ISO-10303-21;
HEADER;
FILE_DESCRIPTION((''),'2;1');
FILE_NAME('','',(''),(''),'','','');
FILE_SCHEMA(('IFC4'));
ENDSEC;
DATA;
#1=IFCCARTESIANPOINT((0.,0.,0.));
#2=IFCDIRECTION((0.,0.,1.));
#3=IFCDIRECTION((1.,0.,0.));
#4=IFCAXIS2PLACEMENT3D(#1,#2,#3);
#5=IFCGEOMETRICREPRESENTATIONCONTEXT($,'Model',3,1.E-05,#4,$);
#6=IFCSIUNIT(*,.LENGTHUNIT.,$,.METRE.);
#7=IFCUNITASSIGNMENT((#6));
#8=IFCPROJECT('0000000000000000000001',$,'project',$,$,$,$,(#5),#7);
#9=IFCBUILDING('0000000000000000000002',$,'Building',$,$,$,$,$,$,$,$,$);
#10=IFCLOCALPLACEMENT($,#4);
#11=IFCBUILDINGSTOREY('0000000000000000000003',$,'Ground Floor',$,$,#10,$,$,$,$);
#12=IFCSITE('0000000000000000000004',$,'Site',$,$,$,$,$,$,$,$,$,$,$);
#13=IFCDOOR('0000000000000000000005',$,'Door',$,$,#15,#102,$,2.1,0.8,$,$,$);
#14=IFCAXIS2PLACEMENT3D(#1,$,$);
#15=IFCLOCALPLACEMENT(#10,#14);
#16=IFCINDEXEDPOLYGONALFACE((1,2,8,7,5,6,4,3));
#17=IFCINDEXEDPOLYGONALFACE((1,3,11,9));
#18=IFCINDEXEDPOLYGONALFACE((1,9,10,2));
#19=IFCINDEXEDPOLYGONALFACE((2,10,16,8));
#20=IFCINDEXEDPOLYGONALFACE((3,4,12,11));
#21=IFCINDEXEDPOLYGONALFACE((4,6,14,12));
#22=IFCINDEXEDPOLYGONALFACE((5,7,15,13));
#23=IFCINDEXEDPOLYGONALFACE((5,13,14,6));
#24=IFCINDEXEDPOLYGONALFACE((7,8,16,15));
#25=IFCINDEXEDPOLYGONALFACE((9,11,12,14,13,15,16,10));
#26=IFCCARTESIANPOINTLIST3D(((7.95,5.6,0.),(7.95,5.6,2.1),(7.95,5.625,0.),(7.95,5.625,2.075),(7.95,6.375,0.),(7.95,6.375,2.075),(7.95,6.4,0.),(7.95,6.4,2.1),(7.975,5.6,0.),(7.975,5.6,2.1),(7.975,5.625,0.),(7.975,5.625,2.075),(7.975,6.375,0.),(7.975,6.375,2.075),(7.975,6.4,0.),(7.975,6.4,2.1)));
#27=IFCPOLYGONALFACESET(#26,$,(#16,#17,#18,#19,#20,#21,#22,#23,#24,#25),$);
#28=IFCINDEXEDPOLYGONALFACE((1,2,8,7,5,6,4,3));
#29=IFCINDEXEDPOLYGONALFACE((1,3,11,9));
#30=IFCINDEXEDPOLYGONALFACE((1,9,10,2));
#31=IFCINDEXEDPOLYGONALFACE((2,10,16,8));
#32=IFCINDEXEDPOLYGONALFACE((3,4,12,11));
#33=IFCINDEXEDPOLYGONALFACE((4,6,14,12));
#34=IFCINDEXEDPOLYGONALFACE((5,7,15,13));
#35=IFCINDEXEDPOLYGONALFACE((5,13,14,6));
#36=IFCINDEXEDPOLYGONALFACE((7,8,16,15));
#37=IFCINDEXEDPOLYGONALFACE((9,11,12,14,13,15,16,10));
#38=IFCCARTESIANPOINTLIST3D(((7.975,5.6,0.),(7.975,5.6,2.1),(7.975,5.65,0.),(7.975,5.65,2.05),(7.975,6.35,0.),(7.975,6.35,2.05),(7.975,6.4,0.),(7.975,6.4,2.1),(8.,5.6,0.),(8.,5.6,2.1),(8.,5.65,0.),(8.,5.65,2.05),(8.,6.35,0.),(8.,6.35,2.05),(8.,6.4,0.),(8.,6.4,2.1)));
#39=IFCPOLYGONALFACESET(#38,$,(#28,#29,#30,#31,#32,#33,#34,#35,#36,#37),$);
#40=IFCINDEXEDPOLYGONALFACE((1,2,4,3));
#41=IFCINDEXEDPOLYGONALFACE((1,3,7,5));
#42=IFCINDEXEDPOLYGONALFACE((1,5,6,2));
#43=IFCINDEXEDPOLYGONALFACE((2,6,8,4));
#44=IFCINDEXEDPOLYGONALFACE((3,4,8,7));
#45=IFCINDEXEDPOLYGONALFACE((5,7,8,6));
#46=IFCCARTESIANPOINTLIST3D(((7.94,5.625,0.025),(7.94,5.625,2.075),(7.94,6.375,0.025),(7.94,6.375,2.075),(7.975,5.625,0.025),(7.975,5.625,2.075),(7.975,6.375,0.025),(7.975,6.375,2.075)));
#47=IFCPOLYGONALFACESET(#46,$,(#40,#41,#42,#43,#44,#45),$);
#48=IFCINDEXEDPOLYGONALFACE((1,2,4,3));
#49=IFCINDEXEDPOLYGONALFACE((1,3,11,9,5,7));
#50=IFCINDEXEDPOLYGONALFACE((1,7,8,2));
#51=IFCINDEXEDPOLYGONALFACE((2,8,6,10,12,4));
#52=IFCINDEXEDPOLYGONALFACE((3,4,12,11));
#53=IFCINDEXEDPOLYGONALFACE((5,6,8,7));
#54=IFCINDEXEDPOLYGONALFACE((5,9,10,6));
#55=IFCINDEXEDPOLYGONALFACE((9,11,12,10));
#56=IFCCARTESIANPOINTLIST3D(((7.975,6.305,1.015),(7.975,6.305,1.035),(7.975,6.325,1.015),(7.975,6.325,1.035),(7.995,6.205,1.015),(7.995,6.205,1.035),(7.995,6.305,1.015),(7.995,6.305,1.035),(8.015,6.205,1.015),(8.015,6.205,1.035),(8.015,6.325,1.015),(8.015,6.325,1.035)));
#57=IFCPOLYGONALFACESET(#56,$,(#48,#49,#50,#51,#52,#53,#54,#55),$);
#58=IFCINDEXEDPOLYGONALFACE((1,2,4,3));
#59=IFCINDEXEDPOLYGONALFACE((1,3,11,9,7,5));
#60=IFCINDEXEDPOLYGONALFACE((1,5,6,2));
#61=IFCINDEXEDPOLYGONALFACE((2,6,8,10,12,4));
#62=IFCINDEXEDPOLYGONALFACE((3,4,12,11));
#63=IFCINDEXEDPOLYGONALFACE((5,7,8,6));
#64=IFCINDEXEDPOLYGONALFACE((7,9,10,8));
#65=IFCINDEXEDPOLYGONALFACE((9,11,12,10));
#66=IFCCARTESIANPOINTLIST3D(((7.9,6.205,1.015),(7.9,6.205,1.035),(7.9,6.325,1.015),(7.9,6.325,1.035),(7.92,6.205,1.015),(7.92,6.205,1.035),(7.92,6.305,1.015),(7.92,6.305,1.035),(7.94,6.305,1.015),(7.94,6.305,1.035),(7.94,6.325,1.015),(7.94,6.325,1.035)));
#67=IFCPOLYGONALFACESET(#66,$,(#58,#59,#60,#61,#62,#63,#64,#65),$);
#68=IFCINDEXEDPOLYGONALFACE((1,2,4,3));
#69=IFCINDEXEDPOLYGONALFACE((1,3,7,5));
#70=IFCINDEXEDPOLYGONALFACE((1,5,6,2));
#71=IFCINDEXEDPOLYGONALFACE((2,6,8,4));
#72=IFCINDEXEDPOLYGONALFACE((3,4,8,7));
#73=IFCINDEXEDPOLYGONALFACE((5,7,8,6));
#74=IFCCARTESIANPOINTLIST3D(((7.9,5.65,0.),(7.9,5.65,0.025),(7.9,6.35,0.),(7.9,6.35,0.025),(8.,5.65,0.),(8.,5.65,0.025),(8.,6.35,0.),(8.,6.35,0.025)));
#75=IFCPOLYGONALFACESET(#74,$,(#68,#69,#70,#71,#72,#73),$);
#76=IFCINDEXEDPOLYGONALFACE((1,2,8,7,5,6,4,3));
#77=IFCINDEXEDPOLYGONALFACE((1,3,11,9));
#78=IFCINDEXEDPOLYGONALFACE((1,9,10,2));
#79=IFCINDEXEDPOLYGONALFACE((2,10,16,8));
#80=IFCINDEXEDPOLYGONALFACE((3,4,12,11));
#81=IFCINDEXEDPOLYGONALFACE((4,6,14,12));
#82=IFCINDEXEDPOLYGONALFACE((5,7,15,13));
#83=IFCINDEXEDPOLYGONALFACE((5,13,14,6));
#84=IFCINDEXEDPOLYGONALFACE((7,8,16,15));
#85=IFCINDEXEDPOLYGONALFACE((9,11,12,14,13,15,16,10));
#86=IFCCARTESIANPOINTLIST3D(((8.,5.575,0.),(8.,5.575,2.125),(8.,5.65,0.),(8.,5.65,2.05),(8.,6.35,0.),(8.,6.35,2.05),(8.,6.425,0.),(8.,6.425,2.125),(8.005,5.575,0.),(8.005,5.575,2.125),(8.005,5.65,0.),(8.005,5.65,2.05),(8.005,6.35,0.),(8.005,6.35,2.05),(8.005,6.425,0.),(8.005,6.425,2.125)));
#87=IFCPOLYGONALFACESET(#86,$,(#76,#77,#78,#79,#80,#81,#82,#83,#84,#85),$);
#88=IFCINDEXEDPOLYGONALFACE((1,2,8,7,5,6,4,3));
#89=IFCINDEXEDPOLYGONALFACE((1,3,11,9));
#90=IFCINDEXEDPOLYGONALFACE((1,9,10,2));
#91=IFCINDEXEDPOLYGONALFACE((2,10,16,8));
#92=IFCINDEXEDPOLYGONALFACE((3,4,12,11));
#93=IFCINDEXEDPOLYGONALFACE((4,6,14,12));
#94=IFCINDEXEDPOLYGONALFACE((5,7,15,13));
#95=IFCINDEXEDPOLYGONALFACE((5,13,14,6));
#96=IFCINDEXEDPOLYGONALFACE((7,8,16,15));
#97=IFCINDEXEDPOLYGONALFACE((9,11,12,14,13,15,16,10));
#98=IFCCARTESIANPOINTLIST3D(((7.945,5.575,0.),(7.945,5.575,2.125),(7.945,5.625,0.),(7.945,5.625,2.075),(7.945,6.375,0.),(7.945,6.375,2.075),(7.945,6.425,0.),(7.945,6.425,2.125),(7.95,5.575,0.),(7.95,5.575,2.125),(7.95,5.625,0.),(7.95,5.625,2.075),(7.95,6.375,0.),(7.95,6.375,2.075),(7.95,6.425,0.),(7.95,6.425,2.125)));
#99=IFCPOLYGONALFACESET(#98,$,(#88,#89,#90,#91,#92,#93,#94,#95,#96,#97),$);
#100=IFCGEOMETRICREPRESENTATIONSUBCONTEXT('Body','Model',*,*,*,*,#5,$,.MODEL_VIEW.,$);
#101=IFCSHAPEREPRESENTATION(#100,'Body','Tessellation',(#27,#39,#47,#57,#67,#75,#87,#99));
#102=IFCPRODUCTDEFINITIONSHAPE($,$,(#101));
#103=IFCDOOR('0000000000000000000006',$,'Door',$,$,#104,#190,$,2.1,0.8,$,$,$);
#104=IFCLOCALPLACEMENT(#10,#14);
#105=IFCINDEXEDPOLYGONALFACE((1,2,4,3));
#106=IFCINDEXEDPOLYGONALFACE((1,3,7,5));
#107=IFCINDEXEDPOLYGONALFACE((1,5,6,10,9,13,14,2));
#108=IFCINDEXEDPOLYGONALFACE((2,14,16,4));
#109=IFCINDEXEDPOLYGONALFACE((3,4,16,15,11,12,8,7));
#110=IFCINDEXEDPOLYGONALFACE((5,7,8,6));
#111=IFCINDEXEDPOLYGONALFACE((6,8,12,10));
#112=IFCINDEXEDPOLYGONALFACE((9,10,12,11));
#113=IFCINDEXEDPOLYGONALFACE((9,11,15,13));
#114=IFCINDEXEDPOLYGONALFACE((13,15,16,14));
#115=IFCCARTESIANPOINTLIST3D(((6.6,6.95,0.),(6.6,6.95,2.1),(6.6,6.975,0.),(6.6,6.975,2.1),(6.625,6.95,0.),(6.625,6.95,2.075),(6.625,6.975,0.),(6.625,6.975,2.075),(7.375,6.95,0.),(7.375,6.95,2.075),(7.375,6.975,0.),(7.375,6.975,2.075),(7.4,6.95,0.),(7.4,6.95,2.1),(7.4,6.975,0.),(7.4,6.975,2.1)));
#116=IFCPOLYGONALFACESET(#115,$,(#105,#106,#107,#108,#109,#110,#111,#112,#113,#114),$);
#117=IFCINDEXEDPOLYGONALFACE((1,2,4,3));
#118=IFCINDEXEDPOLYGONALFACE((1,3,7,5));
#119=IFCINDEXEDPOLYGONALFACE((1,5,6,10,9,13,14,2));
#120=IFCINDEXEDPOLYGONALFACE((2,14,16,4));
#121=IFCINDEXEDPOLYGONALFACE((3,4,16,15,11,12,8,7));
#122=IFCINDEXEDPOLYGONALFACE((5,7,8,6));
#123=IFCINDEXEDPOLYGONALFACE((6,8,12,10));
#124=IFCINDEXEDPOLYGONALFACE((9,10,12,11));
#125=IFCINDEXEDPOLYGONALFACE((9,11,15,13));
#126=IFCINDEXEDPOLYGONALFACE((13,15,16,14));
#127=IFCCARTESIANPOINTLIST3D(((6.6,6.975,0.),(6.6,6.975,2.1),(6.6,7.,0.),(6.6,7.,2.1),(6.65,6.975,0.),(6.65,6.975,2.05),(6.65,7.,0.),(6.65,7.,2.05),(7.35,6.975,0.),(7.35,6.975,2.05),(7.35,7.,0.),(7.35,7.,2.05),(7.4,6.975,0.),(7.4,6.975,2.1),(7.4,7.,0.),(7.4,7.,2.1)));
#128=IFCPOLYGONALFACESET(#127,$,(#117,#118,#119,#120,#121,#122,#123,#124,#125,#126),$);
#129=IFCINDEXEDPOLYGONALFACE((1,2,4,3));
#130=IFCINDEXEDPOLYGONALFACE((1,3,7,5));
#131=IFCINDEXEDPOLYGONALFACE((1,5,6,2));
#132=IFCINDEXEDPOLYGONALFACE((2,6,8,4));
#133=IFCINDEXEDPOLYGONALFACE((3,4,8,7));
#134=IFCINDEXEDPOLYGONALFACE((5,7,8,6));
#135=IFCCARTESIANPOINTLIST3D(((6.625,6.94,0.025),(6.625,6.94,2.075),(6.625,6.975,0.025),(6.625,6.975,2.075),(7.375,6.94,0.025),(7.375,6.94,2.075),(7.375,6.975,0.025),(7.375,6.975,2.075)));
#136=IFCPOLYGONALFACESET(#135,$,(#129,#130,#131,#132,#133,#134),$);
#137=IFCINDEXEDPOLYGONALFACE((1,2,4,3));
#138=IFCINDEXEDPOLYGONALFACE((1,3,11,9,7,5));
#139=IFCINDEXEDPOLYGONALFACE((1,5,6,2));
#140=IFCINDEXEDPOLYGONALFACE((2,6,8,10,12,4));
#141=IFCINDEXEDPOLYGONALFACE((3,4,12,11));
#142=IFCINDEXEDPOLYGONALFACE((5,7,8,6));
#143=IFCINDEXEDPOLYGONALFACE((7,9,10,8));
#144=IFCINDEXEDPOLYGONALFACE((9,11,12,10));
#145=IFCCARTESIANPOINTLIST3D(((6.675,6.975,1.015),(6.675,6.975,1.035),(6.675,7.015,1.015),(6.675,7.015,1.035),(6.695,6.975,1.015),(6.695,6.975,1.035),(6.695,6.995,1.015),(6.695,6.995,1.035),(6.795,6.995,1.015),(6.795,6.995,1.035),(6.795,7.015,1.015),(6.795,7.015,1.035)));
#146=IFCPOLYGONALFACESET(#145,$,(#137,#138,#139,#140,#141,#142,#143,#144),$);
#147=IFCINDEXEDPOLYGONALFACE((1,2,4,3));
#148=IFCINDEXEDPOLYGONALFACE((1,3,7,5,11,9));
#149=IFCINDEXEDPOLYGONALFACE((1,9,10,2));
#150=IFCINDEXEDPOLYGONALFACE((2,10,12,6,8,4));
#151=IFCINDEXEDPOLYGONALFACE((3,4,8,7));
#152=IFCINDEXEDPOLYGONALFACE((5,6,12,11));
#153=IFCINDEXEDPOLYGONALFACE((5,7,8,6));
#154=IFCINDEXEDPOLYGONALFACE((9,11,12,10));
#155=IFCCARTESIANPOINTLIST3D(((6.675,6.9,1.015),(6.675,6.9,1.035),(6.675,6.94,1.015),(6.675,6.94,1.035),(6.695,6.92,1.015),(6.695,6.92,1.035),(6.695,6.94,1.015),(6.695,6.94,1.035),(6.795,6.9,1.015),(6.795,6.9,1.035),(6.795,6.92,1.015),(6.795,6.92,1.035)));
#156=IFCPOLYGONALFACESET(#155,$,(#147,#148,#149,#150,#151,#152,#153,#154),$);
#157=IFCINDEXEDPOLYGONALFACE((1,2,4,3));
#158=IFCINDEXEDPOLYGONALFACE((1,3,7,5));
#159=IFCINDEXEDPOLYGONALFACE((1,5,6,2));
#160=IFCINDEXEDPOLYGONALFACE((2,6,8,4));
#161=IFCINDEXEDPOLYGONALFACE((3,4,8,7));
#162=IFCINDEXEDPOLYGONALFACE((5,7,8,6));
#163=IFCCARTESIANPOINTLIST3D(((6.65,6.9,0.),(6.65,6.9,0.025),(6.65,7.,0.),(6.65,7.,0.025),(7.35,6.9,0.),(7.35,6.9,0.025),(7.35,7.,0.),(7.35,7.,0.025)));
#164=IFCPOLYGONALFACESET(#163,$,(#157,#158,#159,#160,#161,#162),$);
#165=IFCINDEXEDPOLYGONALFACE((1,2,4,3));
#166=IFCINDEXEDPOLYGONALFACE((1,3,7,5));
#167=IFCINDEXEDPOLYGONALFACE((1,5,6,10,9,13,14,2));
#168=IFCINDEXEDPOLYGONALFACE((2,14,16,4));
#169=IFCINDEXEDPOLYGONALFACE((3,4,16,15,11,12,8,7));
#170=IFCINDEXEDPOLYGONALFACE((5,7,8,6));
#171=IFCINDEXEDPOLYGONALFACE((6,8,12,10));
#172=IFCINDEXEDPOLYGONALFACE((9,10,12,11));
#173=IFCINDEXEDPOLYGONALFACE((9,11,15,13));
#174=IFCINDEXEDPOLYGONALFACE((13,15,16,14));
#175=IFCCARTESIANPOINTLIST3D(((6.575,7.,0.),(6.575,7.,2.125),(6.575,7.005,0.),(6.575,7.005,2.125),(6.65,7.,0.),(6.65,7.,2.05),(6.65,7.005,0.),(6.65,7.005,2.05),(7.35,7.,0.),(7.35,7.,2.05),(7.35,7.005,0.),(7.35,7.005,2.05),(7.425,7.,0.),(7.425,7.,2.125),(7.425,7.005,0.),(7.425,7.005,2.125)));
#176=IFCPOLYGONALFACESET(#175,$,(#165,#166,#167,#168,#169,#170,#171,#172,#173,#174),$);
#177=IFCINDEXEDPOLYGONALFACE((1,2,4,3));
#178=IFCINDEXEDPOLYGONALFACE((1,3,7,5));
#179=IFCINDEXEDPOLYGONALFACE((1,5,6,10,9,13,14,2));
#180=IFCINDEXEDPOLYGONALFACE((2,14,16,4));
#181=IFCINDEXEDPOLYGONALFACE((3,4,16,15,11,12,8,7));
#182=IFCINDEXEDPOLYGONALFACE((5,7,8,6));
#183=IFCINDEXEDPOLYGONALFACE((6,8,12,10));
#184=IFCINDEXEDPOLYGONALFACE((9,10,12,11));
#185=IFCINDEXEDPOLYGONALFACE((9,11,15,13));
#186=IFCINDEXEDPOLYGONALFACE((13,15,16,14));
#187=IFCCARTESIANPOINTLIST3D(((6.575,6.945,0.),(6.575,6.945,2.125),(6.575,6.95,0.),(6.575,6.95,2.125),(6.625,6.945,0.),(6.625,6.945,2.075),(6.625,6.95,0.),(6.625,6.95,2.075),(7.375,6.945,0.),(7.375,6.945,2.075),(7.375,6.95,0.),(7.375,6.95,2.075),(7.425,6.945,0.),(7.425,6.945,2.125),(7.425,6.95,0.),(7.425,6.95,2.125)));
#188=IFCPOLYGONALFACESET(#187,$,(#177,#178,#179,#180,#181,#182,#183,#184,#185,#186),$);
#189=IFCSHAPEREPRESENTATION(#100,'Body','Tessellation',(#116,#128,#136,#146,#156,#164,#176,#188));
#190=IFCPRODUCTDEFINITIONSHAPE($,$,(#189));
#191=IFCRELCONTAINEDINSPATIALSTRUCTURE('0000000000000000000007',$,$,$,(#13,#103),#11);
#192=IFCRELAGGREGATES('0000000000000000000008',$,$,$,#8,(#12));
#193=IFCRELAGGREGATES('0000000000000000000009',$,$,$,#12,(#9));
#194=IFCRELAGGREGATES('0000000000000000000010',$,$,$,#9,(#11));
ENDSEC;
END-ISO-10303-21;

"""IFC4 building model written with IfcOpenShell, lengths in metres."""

from ifc_helpers import new_model, si_unit, frame, origin_with_axes, place, context, subcontext, project, spatial, line, indexed_curve, outline, extrude, element, save


model = new_model("IFC4")

# Units and contexts
model_context = context("Model", 3, precision=1e-05, world=origin_with_axes())
body_context = subcontext(model_context, "Body", "Model", "MODEL_VIEW")
ifc_project = project(units=[si_unit("LENGTHUNIT", "METRE")], contexts=[model_context])

# Site, building, storey
site = spatial("IfcSite", under=ifc_project, Name="Site")
building = spatial("IfcBuilding", under=site, Name="Building")
storey_placement = place(None, origin_with_axes())
storey = spatial("IfcBuildingStorey", under=building, at=storey_placement, Name="Ground Floor")

# Doors
door_1_placement = place(storey_placement, frame((8.0, 5.6, 0.0), z_axis=(0.0, 0.0, 1.0), x_axis=(0.0, 1.0, 0.0)))
element("IfcDoor", 1, at=door_1_placement, inside=storey, Name="Door", OverallHeight=2.1, OverallWidth=0.8, context=body_context, shape_type="SweptSolid", body=[
    extrude(outline(indexed_curve([(0.0, 0.0), (0.0, 2.1), (0.8, 2.1), (0.8, 0.0), (0.775, 0.0), (0.775, 2.075), (0.025, 2.075), (0.025, 0.0)], segments=[line(1, 2, 3, 4, 5, 6, 7, 8, 1)])), frame((0.0, 0.025, 0.0), z_axis=(0.0, -1.0, 0.0), x_axis=(1.0, 0.0, 0.0)), (0.0, 0.0, -1.0), 0.025),
    extrude(outline(indexed_curve([(0.0, 0.0), (0.0, 2.1), (0.8, 2.1), (0.8, 0.0), (0.75, 0.0), (0.75, 2.05), (0.05, 2.05), (0.05, 0.0)], segments=[line(1, 2, 3, 4, 5, 6, 7, 8, 1)])), frame((0.0, 0.0, 0.0), z_axis=(0.0, -1.0, 0.0), x_axis=(1.0, 0.0, 0.0)), (0.0, 0.0, -1.0), 0.025),
    extrude(outline(indexed_curve([(0.0, 0.0), (0.75, 0.0), (0.75, 0.035), (0.0, 0.035)], segments=[line(1, 2, 3, 4, 1)])), frame((0.025, 0.025, 0.025), z_axis=(0.0, 0.0, 1.0), x_axis=(1.0, 0.0, 0.0)), (0.0, 0.0, 1.0), 2.05),
    extrude(outline(indexed_curve([(0.0, 0.0), (0.0, -0.04), (-0.12, -0.04), (-0.12, -0.02), (-0.02, -0.02), (-0.02, 0.0)], segments=[line(1, 2, 3, 4, 5, 6, 1)])), frame((0.725, 0.025, 1.015), z_axis=(0.0, 0.0, 1.0), x_axis=(1.0, 0.0, 0.0)), (0.0, 0.0, 1.0), 0.02),
    extrude(outline(indexed_curve([(0.0, 0.0), (0.0, 0.04), (-0.12, 0.04), (-0.12, 0.02), (-0.02, 0.02), (-0.02, 0.0)], segments=[line(1, 2, 3, 4, 5, 6, 1)])), frame((0.725, 0.06, 1.015), z_axis=(0.0, 0.0, 1.0), x_axis=(1.0, 0.0, 0.0)), (0.0, 0.0, 1.0), 0.02),
    extrude(outline(indexed_curve([(0.0, 0.0), (0.7, 0.0), (0.7, 0.1), (0.0, 0.1)], segments=[line(1, 2, 3, 4, 1)])), frame((0.05, 0.0, 0.0), z_axis=(0.0, 0.0, 1.0), x_axis=(1.0, 0.0, 0.0)), (0.0, 0.0, 1.0), 0.025),
    extrude(outline(indexed_curve([(0.0, 0.0), (0.0, 2.125), (0.85, 2.125), (0.85, 0.0), (0.775, 0.0), (0.775, 2.05), (0.075, 2.05), (0.075, 0.0)], segments=[line(1, 2, 3, 4, 5, 6, 7, 8, 1)])), frame((-0.025, -0.005, 0.0), z_axis=(0.0, -1.0, 0.0), x_axis=(1.0, 0.0, 0.0)), (0.0, 0.0, -1.0), 0.005),
    extrude(outline(indexed_curve([(0.0, 0.0), (0.0, 2.125), (0.85, 2.125), (0.85, 0.0), (0.8, 0.0), (0.8, 2.075), (0.05, 2.075), (0.05, 0.0)], segments=[line(1, 2, 3, 4, 5, 6, 7, 8, 1)])), frame((-0.025, 0.05, 0.0), z_axis=(0.0, -1.0, 0.0), x_axis=(1.0, 0.0, 0.0)), (0.0, 0.0, -1.0), 0.005),
])
door_2_placement = place(storey_placement, frame((7.4, 7.0, 0.0), z_axis=(0.0, 0.0, 1.0), x_axis=(-1.0, 0.0, 0.0)))
element("IfcDoor", 2, at=door_2_placement, inside=storey, Name="Door", OverallHeight=2.1, OverallWidth=0.8, context=body_context, shape_type="SweptSolid", body=[
    extrude(outline(indexed_curve([(0.0, 0.0), (0.0, 2.1), (0.8, 2.1), (0.8, 0.0), (0.775, 0.0), (0.775, 2.075), (0.025, 2.075), (0.025, 0.0)], segments=[line(1, 2, 3, 4, 5, 6, 7, 8, 1)])), frame((0.0, 0.025, 0.0), z_axis=(0.0, -1.0, 0.0), x_axis=(1.0, 0.0, 0.0)), (0.0, 0.0, -1.0), 0.025),
    extrude(outline(indexed_curve([(0.0, 0.0), (0.0, 2.1), (0.8, 2.1), (0.8, 0.0), (0.75, 0.0), (0.75, 2.05), (0.05, 2.05), (0.05, 0.0)], segments=[line(1, 2, 3, 4, 5, 6, 7, 8, 1)])), frame((0.0, 0.0, 0.0), z_axis=(0.0, -1.0, 0.0), x_axis=(1.0, 0.0, 0.0)), (0.0, 0.0, -1.0), 0.025),
    extrude(outline(indexed_curve([(0.0, 0.0), (0.75, 0.0), (0.75, 0.035), (0.0, 0.035)], segments=[line(1, 2, 3, 4, 1)])), frame((0.025, 0.025, 0.025), z_axis=(0.0, 0.0, 1.0), x_axis=(1.0, 0.0, 0.0)), (0.0, 0.0, 1.0), 2.05),
    extrude(outline(indexed_curve([(0.0, 0.0), (0.0, -0.04), (-0.12, -0.04), (-0.12, -0.02), (-0.02, -0.02), (-0.02, 0.0)], segments=[line(1, 2, 3, 4, 5, 6, 1)])), frame((0.725, 0.025, 1.015), z_axis=(0.0, 0.0, 1.0), x_axis=(1.0, 0.0, 0.0)), (0.0, 0.0, 1.0), 0.02),
    extrude(outline(indexed_curve([(0.0, 0.0), (0.0, 0.04), (-0.12, 0.04), (-0.12, 0.02), (-0.02, 0.02), (-0.02, 0.0)], segments=[line(1, 2, 3, 4, 5, 6, 1)])), frame((0.725, 0.06, 1.015), z_axis=(0.0, 0.0, 1.0), x_axis=(1.0, 0.0, 0.0)), (0.0, 0.0, 1.0), 0.02),
    extrude(outline(indexed_curve([(0.0, 0.0), (0.7, 0.0), (0.7, 0.1), (0.0, 0.1)], segments=[line(1, 2, 3, 4, 1)])), frame((0.05, 0.0, 0.0), z_axis=(0.0, 0.0, 1.0), x_axis=(1.0, 0.0, 0.0)), (0.0, 0.0, 1.0), 0.025),
    extrude(outline(indexed_curve([(0.0, 0.0), (0.0, 2.125), (0.85, 2.125), (0.85, 0.0), (0.775, 0.0), (0.775, 2.05), (0.075, 2.05), (0.075, 0.0)], segments=[line(1, 2, 3, 4, 5, 6, 7, 8, 1)])), frame((-0.025, -0.005, 0.0), z_axis=(0.0, -1.0, 0.0), x_axis=(1.0, 0.0, 0.0)), (0.0, 0.0, -1.0), 0.005),
    extrude(outline(indexed_curve([(0.0, 0.0), (0.0, 2.125), (0.85, 2.125), (0.85, 0.0), (0.8, 0.0), (0.8, 2.075), (0.05, 2.075), (0.05, 0.0)], segments=[line(1, 2, 3, 4, 5, 6, 7, 8, 1)])), frame((-0.025, 0.05, 0.0), z_axis=(0.0, -1.0, 0.0), x_axis=(1.0, 0.0, 0.0)), (0.0, 0.0, -1.0), 0.005),
])

save(model, "model.ifc")
